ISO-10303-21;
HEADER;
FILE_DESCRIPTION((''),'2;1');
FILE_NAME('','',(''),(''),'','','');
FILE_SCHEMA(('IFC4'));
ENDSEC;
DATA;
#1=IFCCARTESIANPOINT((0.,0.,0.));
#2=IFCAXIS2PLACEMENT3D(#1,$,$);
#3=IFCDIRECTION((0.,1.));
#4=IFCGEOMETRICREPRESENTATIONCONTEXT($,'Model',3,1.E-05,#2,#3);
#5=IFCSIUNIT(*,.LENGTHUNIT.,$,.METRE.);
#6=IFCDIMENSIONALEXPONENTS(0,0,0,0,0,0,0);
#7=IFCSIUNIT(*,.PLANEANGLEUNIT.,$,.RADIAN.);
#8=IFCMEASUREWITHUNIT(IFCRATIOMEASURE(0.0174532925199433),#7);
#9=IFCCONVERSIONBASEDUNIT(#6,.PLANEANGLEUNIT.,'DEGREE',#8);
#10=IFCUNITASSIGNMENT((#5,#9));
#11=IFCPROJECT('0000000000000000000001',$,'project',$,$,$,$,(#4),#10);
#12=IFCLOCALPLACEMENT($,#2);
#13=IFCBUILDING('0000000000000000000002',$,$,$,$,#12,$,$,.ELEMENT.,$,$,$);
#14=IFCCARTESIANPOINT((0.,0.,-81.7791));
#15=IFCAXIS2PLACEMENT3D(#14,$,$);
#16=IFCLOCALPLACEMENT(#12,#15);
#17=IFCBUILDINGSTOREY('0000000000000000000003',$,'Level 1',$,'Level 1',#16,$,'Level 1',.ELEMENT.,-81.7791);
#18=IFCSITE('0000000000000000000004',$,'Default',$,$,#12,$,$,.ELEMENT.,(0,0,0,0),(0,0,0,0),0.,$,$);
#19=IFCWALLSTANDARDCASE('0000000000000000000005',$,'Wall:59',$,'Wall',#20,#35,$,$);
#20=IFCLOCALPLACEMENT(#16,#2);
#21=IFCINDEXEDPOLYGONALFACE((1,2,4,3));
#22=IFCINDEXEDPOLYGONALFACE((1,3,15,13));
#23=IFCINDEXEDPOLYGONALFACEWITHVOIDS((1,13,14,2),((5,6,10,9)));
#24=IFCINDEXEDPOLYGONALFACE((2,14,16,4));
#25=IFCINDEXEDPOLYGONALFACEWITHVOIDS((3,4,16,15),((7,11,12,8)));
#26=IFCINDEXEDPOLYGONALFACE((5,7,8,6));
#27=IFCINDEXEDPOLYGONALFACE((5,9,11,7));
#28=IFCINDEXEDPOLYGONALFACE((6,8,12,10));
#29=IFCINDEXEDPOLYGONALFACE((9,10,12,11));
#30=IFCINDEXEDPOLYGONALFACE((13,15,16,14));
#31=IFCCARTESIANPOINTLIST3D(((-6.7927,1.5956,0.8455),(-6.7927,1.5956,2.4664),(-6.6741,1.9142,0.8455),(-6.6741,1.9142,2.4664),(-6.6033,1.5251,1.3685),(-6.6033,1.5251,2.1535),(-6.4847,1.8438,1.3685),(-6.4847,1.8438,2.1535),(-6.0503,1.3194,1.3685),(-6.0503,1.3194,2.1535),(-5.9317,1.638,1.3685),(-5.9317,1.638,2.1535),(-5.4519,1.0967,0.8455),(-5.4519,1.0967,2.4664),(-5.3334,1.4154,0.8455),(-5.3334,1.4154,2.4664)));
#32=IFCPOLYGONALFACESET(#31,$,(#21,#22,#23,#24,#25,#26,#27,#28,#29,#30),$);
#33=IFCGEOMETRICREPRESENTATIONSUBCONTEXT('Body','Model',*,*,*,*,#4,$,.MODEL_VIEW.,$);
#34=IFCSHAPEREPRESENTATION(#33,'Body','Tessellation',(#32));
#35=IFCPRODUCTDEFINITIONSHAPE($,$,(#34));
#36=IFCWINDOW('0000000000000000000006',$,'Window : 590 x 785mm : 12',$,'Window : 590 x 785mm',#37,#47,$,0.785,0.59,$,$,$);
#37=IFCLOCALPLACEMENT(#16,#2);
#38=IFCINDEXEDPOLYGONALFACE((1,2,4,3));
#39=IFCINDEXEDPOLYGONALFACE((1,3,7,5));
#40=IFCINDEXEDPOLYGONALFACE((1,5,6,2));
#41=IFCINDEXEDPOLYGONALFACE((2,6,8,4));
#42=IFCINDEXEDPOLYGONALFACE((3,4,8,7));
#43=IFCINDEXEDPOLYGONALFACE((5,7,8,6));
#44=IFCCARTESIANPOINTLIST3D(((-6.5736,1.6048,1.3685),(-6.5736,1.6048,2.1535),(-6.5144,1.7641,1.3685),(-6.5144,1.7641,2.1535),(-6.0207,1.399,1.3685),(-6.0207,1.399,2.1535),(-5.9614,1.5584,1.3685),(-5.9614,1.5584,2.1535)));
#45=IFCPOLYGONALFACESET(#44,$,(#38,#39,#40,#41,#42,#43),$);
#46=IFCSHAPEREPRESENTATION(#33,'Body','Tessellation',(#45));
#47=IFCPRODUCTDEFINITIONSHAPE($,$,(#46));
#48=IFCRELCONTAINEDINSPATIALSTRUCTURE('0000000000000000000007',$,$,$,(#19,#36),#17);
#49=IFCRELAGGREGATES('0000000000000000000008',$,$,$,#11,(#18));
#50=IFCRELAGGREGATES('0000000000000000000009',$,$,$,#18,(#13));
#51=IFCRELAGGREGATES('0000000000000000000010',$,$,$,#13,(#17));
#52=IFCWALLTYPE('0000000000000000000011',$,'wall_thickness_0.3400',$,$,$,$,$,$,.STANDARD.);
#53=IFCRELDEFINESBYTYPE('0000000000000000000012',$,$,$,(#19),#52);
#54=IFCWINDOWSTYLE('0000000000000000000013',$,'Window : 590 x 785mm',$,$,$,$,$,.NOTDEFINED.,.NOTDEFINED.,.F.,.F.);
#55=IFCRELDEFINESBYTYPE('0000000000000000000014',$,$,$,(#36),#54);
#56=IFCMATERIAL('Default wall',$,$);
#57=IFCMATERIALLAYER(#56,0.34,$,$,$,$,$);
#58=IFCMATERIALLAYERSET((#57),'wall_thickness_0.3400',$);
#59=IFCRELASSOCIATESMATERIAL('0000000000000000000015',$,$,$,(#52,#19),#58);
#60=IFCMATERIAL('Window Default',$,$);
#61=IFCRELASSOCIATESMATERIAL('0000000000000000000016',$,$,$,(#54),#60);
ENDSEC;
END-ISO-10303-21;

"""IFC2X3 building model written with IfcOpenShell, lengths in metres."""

from ifc_helpers import new_model, entity, si_unit, converted_unit, direction, frame, frame_2d, origin, origin_2d_with_axis, place, context, subcontext, project, spatial, polyline, rectangle, outline, extrude, source, transform, mapped, material, layer, layer_set, layer_usage, type_object, type_shapes, element, fill, save


model = new_model("IFC2X3")

# Units and contexts
model_context = context("Model", 3, precision=1e-05, world=origin(), true_north=direction((0.0, 1.0)))
body_context = subcontext(model_context, "Body", "Model", "MODEL_VIEW")
ifc_project = project(units=[si_unit("LENGTHUNIT", "METRE"), converted_unit("PLANEANGLEUNIT", "DEGREE", entity("IfcRatioMeasure", 0.0174532925199433), si_unit("PLANEANGLEUNIT", "RADIAN"), dimensions=[0, 0, 0, 0, 0, 0, 0])], contexts=[model_context])

# Site, building, storey
placement_1 = place(None, origin())
site = spatial("IfcSite", under=ifc_project, at=placement_1, Name="Default", CompositionType="ELEMENT", RefLatitude=(0, 0, 0, 0), RefLongitude=(0, 0, 0, 0), RefElevation=0.0)
building = spatial("IfcBuilding", under=site, at=placement_1, CompositionType="ELEMENT")
storey_placement = place(placement_1, frame((0.0, 0.0, -81.7791)))
storey = spatial("IfcBuildingStorey", under=building, at=storey_placement, Name="Level 1", ObjectType="Level 1", LongName="Level 1", CompositionType="ELEMENT", Elevation=-81.7791)

# Shared definitions
ifc_material_1 = material(Name="Default wall")

# Shared definitions
ifc_material_2 = material(Name="Window Default")

# Wall, opening, window
ifc_layer_1 = layer(ifc_material_1, 0.34)
ifc_layer_set_1 = layer_set([ifc_layer_1], Name="wall_thickness_0.3400")
ifc_layer_usage_1 = layer_usage(ifc_layer_set_1, "AXIS2", "POSITIVE", -0.17)
wall_type_1 = type_object("IfcWallType", Name="wall_thickness_0.3400", PredefinedType="STANDARD", material=ifc_layer_set_1)
placement_2 = place(placement_1, frame((0.0, 0.0, -80.9336)))
wall_1_placement = place(placement_2, frame((-6.7334, 1.7549, 0.0), z_axis=(0.0, 0.0, 1.0), x_axis=(0.93723, -0.348711, 0.0)))
wall_1 = element("IfcWallStandardCase", 1, at=wall_1_placement, inside=storey, type_object=wall_type_1, material=ifc_layer_usage_1, Name="Wall:59", ObjectType="Wall", context=body_context, shape_type="SweptSolid", body=[
    extrude(outline(polyline([(1.4305, -0.17), (1.4305, 0.17), (0.0, 0.17), (0.0, -0.17), (1.4305, -0.17)])), origin(), (0.0, 0.0, 1.0), 1.6209),
])
opening_1_placement = place(wall_1_placement, frame((0.2021, -0.17, 0.523)))
opening_1 = element("IfcOpeningElement", 2, at=opening_1_placement, cuts=wall_1, ObjectType="Opening", context=body_context, shape_type="SweptSolid", body=[
    extrude(rectangle(XDim=0.59, YDim=0.785, at=frame_2d((0.3925, 0.295), x_axis=(0.0, 1.0))), frame((0.0, 0.0, 0.0), z_axis=(0.0, 1.0, 0.0), x_axis=(0.0, 0.0, 1.0)), (0.0, 0.0, 1.0), 0.34),
])
window_style_1 = type_object("IfcWindowStyle", Name="Window : 590 x 785mm", ConstructionType="NOTDEFINED", OperationType="NOTDEFINED", ParameterTakesPrecedence=False, Sizeable=False, material=ifc_material_2)
shared_shape_1 = source(origin(), body_context, "Body", "SweptSolid", [
    extrude(rectangle(XDim=0.17, YDim=0.59, at=origin_2d_with_axis()), frame((0.295, 0.17, 0.0), z_axis=(0.0, 0.0, 1.0), x_axis=(0.0, 1.0, 0.0)), (0.0, 0.0, 1.0), 0.785),
])
type_shapes(window_style_1, [shared_shape_1])
window_1_placement = place(opening_1_placement, origin())
window_1 = element("IfcWindow", 3, at=window_1_placement, inside=storey, type_object=window_style_1, Name="Window : 590 x 785mm : 12", ObjectType="Window : 590 x 785mm", OverallHeight=0.785, OverallWidth=0.59, context=body_context, shape_type="MappedRepresentation", body=[
    mapped(shared_shape_1, transform((0.0, 0.0, 0.0), scale=1.0)),
])
fill(opening_1, window_1)

save(model, "model.ifc")
